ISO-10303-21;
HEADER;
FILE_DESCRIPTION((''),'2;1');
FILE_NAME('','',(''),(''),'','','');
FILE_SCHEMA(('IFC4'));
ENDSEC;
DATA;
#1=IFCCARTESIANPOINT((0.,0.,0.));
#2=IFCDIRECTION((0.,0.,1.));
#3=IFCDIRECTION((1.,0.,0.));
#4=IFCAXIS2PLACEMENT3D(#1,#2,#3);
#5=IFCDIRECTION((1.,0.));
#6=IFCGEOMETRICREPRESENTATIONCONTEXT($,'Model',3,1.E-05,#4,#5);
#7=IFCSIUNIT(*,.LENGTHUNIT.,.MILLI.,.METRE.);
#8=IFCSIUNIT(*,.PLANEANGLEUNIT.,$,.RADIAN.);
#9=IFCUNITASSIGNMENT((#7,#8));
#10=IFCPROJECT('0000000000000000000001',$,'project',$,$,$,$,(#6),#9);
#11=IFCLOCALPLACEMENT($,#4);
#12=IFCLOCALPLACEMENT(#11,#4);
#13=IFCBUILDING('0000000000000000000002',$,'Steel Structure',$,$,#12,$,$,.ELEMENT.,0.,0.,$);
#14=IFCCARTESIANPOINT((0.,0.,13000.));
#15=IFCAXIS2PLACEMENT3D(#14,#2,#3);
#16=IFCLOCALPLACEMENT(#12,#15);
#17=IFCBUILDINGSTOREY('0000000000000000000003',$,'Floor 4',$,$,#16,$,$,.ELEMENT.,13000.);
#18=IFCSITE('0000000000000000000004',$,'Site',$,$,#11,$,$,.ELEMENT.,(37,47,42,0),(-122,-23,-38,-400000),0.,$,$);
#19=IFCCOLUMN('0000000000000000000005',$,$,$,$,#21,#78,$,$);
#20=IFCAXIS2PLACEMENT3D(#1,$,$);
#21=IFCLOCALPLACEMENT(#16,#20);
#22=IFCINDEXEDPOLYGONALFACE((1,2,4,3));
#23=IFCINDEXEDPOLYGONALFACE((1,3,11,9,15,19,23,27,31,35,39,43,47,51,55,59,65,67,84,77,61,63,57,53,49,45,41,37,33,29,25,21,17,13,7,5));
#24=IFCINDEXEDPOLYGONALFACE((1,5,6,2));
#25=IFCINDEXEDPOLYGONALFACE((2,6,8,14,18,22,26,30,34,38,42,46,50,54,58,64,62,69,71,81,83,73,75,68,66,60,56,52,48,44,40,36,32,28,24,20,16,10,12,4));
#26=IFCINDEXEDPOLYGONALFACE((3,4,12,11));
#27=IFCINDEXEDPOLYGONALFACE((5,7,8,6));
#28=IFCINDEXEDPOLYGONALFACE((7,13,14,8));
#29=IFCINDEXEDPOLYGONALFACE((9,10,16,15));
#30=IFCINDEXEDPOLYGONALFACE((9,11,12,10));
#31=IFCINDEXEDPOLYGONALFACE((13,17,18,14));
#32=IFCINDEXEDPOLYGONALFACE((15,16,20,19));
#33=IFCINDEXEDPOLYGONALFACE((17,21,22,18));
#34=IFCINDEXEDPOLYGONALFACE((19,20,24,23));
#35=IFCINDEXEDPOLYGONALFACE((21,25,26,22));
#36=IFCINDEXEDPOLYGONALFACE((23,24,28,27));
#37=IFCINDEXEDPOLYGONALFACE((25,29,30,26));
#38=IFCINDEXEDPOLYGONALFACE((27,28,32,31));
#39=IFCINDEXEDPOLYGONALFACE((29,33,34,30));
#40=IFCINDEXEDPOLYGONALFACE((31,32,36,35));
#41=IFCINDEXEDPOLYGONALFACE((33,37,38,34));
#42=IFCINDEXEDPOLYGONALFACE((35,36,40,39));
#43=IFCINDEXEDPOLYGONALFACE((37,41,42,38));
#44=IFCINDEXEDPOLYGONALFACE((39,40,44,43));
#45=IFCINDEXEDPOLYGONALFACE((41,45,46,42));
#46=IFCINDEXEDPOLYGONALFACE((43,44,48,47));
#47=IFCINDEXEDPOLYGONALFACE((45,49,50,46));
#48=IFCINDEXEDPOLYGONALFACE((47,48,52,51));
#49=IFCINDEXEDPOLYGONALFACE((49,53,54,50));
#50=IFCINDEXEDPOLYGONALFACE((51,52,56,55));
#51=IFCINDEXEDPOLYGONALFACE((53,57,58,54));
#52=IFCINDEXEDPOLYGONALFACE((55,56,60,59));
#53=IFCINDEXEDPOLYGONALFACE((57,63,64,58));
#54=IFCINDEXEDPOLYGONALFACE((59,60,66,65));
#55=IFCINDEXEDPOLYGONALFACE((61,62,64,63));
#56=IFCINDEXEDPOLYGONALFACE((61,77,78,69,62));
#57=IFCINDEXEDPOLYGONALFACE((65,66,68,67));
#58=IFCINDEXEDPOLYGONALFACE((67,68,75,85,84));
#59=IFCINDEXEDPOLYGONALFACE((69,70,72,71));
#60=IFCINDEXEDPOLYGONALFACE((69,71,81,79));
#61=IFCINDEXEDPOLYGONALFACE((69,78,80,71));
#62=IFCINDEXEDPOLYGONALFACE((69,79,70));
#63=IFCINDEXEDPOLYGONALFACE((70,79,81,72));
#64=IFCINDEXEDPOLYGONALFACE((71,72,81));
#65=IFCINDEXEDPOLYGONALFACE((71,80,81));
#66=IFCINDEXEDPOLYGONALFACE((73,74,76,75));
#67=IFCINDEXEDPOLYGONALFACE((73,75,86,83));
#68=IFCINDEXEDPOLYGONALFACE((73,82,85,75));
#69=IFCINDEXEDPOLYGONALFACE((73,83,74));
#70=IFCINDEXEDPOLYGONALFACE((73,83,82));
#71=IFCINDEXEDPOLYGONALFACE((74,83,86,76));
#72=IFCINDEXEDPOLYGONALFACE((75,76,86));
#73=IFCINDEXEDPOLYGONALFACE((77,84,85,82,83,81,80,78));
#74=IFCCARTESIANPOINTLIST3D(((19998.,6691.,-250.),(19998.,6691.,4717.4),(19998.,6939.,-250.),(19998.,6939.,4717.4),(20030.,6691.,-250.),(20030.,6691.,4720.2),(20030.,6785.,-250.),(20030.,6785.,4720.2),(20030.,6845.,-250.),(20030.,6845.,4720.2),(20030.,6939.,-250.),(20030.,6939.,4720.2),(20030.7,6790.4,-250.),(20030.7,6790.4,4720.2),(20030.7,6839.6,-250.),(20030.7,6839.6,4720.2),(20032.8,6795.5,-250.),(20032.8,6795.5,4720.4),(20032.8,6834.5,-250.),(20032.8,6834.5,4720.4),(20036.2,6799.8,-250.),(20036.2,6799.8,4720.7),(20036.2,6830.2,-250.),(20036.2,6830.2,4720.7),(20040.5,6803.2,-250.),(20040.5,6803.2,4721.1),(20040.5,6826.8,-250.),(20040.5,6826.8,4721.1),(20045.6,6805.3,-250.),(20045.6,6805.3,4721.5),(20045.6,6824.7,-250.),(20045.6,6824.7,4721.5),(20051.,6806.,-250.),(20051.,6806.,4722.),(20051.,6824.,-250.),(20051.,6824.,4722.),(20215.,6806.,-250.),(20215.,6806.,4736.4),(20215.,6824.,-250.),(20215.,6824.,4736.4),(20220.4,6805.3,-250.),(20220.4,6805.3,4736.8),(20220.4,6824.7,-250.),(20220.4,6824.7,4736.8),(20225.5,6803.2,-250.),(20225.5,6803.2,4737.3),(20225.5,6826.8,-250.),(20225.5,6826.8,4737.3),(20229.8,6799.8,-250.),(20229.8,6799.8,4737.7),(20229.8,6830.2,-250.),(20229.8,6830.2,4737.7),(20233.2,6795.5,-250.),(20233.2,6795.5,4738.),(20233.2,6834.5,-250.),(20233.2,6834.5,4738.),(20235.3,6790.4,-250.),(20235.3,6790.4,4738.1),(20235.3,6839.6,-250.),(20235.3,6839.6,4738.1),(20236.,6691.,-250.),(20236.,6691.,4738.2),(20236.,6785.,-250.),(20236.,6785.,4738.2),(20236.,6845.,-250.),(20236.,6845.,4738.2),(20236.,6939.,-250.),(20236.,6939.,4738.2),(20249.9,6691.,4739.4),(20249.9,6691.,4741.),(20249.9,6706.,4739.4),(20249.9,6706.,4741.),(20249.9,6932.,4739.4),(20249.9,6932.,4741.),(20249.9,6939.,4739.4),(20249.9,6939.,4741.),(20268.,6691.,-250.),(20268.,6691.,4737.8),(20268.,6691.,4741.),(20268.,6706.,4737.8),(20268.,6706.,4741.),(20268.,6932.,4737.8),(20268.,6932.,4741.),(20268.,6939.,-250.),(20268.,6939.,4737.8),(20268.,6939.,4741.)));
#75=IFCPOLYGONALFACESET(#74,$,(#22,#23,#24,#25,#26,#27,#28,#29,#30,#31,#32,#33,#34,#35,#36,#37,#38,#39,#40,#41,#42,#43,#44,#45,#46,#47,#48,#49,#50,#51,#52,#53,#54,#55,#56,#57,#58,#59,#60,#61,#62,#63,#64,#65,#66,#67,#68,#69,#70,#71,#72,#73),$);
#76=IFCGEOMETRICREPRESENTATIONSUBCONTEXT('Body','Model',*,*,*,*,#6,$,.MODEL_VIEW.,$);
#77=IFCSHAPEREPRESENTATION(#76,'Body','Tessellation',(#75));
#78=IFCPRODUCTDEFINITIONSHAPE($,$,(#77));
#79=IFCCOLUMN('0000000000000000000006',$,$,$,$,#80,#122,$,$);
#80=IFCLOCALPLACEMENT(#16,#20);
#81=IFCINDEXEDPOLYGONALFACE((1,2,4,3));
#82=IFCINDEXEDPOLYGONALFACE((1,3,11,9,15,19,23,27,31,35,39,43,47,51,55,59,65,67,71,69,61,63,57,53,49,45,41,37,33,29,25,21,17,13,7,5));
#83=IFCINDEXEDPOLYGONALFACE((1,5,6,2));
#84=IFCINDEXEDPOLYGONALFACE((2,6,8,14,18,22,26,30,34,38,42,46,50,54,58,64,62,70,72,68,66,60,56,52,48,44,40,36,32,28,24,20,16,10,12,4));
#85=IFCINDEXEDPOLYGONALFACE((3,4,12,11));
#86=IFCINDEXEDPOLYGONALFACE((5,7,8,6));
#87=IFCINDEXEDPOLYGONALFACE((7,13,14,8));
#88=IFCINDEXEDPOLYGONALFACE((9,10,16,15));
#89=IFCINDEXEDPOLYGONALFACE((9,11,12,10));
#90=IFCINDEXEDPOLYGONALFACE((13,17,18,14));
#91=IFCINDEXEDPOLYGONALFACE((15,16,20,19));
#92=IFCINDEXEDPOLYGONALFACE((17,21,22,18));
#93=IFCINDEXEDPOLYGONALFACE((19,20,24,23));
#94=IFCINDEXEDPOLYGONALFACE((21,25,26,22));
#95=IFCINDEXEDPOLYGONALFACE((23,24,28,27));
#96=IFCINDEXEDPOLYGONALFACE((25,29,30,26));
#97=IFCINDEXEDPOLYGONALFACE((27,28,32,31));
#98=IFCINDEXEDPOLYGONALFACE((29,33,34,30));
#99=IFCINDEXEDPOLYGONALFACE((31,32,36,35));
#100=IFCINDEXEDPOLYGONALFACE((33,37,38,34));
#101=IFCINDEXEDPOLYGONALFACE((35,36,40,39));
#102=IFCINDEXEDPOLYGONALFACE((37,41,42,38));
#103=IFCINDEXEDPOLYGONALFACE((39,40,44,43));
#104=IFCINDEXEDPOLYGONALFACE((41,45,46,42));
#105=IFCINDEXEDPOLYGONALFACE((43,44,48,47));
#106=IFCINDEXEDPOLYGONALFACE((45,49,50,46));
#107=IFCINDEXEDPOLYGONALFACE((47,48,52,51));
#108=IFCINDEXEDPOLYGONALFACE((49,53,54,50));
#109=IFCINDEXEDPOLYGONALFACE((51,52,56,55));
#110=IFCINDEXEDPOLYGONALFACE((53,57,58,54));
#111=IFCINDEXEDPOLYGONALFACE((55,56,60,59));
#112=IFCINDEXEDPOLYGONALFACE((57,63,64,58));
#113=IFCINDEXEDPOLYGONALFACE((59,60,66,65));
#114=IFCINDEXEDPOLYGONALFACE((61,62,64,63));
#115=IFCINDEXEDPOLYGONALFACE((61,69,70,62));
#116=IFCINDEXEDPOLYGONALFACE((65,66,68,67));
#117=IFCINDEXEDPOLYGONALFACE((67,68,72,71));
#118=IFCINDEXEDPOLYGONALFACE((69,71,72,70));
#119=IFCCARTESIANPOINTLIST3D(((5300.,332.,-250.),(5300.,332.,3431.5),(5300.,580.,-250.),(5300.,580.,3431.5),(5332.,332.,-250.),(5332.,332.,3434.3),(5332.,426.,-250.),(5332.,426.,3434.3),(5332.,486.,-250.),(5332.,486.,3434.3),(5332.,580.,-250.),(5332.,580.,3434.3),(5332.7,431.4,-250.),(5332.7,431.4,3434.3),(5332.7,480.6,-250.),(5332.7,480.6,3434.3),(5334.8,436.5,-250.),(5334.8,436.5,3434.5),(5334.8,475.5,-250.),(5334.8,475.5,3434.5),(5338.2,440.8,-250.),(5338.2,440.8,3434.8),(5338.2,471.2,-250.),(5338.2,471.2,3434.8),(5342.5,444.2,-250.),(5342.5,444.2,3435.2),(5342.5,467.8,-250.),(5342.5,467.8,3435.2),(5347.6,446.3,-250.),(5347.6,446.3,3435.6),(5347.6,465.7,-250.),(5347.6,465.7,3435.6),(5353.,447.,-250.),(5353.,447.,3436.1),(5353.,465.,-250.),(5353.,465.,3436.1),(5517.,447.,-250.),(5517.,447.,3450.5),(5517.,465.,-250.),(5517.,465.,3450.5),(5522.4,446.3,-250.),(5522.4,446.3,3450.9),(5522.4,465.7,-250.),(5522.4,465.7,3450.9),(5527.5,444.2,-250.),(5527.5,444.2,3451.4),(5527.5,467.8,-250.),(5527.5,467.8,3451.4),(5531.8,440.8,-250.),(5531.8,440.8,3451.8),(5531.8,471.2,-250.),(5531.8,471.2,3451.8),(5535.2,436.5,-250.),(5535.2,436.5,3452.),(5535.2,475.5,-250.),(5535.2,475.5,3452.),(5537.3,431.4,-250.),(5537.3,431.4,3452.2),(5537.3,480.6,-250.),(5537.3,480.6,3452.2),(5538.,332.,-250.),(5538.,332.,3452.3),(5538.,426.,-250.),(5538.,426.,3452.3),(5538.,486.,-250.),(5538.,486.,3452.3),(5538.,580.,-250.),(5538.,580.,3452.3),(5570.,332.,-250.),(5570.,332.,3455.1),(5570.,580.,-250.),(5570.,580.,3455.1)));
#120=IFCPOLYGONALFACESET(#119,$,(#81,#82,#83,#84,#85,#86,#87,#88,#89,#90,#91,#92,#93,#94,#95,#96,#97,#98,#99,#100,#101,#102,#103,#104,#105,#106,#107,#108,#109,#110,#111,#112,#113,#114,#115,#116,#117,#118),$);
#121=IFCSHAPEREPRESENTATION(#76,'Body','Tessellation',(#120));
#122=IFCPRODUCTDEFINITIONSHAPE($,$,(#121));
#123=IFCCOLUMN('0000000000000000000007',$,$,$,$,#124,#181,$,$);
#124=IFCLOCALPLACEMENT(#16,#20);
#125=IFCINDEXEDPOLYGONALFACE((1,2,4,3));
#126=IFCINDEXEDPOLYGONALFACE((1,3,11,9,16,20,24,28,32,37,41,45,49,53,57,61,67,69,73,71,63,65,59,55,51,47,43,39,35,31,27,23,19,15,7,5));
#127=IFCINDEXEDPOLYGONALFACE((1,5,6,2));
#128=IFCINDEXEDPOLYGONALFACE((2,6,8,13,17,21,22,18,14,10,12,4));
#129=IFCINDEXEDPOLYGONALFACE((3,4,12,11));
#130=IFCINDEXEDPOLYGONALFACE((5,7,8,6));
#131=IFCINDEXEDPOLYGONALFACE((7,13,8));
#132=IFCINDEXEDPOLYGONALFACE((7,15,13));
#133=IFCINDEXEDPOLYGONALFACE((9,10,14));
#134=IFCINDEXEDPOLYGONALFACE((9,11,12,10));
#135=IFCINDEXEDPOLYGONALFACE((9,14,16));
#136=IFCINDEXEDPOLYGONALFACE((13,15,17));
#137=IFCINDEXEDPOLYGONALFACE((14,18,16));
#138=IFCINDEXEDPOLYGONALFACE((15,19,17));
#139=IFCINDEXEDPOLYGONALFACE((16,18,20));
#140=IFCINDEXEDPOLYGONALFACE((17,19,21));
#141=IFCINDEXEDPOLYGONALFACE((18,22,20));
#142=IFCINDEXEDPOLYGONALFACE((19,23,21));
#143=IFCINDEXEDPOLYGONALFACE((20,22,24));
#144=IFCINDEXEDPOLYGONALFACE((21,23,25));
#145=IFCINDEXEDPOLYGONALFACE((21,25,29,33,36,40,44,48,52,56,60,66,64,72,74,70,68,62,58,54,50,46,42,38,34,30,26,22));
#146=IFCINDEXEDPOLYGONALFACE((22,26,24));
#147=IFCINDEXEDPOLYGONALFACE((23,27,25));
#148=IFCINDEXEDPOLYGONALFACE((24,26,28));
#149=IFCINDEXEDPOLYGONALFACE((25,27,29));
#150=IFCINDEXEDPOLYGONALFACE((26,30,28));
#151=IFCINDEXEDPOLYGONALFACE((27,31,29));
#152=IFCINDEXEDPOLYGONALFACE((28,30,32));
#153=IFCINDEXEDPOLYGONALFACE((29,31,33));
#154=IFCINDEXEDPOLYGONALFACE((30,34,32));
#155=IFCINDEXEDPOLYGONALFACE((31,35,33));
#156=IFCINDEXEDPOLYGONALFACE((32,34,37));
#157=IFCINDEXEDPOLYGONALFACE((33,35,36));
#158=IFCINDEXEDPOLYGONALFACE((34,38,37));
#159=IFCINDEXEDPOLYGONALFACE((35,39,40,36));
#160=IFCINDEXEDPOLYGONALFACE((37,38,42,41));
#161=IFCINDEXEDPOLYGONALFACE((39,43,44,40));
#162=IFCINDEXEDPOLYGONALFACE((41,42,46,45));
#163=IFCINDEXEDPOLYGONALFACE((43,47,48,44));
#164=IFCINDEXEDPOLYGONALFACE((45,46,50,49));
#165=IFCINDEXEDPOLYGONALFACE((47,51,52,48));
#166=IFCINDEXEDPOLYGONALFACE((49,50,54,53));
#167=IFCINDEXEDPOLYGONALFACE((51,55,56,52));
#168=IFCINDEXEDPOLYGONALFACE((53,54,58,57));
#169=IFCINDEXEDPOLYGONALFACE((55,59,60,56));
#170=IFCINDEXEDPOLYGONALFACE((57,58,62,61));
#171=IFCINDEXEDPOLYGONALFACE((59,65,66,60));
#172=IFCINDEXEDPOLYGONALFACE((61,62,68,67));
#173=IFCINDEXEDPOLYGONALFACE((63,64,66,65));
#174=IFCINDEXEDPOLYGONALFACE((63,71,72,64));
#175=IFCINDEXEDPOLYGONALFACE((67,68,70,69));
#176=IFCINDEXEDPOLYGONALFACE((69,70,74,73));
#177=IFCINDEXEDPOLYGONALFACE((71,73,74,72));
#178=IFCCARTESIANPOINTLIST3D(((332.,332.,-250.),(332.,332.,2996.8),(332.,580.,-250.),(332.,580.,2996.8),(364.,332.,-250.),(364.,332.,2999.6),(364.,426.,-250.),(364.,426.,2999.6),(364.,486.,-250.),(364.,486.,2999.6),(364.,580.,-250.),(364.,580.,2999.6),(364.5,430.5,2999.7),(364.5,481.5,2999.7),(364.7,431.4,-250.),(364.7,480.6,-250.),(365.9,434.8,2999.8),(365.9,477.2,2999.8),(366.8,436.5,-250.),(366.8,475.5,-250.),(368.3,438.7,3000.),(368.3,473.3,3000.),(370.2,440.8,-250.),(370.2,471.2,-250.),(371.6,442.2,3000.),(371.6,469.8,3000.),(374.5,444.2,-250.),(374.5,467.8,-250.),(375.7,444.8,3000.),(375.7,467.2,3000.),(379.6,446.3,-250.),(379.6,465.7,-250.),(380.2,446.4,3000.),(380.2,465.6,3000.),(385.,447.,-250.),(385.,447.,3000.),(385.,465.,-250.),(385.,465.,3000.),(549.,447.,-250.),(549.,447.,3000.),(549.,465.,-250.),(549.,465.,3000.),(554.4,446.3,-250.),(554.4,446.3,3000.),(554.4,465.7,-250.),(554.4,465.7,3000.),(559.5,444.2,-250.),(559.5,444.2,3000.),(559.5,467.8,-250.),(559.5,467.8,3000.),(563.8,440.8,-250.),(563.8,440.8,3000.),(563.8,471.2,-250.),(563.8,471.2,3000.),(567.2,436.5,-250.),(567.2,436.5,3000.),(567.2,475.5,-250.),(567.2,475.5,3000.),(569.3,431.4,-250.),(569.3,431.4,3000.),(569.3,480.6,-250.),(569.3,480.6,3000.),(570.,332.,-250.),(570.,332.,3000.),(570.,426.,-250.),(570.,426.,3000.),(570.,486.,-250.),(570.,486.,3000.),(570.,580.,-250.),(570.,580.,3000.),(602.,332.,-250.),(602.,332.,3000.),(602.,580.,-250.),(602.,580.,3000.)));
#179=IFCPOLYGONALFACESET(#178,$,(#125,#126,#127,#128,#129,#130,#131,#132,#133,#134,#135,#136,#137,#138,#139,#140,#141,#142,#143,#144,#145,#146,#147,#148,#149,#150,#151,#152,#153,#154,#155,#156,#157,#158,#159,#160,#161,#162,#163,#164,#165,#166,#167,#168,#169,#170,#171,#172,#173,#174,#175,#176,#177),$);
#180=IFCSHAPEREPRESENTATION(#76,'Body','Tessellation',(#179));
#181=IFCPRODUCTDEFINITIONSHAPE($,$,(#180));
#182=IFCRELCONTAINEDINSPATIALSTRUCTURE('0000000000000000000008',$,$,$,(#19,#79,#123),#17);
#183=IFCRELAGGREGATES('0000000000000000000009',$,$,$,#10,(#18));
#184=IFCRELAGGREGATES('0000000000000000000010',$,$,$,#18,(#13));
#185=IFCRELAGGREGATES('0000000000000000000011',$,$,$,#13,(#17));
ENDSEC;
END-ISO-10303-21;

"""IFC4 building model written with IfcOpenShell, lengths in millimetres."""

from ifc_helpers import new_model, si_unit, direction, frame, origin_with_axes, origin_2d_with_axis, place, context, subcontext, project, spatial, polyline, i_section, outline, extrude, boolean, clip, bounded_halfspace, element, save


model = new_model("IFC4")

# Units and contexts
model_context = context("Model", 3, precision=1e-05, world=origin_with_axes(), true_north=direction((1.0, 0.0)))
body_context = subcontext(model_context, "Body", "Model", "MODEL_VIEW")
ifc_project = project(units=[si_unit("LENGTHUNIT", "METRE", prefix="MILLI"), si_unit("PLANEANGLEUNIT", "RADIAN")], contexts=[model_context])

# Site, building, storey
site_placement = place(None, origin_with_axes())
site = spatial("IfcSite", under=ifc_project, at=site_placement, Name="Site", CompositionType="ELEMENT", RefLatitude=(37, 47, 42, 0), RefLongitude=(-122, -23, -38, -400000), RefElevation=0.0)
building_placement = place(site_placement, origin_with_axes())
building = spatial("IfcBuilding", under=site, at=building_placement, Name="Steel Structure", CompositionType="ELEMENT", ElevationOfRefHeight=0.0, ElevationOfTerrain=0.0)
storey_placement = place(building_placement, frame((0.0, 0.0, 13000.0), z_axis=(0.0, 0.0, 1.0), x_axis=(1.0, 0.0, 0.0)))
storey = spatial("IfcBuildingStorey", under=building, at=storey_placement, Name="Floor 4", CompositionType="ELEMENT", Elevation=13000.0)

# Columns
column_1_placement = place(storey_placement, frame((20133.0, 6815.0, -250.0), z_axis=(0.0, 0.0, 1.0), x_axis=(0.0, 1.0, 0.0)))
element("IfcColumn", 1, at=column_1_placement, inside=storey, context=body_context, shape_type="SolidModel", body=[
    boolean("DIFFERENCE", boolean("DIFFERENCE", clip(extrude(i_section(OverallWidth=248.0, OverallDepth=270.0, WebThickness=18.0, FlangeThickness=32.0, FilletRadius=21.0, at=origin_2d_with_axis()), origin_with_axes(), (0.0, 0.0, 1.0), 4991.0), bounded_halfspace(frame((-6815.0, 21519.4, 3096.5), z_axis=(0.0, 0.087156, 0.996195), x_axis=(-1.0, 0.0, 0.0)), False, origin_with_axes(), polyline([(-124.0, 103.0), (-30.0, 103.0), (-9.0, 82.0), (-9.0, -82.0), (-30.0, -103.0), (-124.0, -103.0), (-124.0, -116.9), (-109.0, -116.9), (-109.0, -135.0), (117.0, -135.0), (117.0, -116.9), (124.0, -116.9), (124.0, -103.0), (30.0, -103.0), (9.0, -82.0), (9.0, 82.0), (30.0, 103.0), (124.0, 103.0), (124.0, 135.0), (-124.0, 135.0), (-124.0, 103.0)]))), extrude(outline(polyline([(1.6, 6.0), (0.0, -12.1), (-1.6, 6.0), (1.6, 6.0)])), frame((117.0, -129.0, 4989.4), z_axis=(1.0, 0.0, 0.0), x_axis=(0.0, 0.0, 1.0)), (0.0, 0.0, 1.0), 7.0)), extrude(outline(polyline([(0.0, -12.1), (-1.6, 6.0), (1.6, 6.0), (0.0, -12.1)])), frame((-124.0, -129.0, 4989.4), z_axis=(1.0, 0.0, 0.0), x_axis=(0.0, 0.0, 1.0)), (0.0, 0.0, 1.0), 15.0)),
])
column_2_placement = place(storey_placement, frame((5435.0, 456.0, -250.0), z_axis=(0.0, 0.0, 1.0), x_axis=(0.0, 1.0, 0.0)))
element("IfcColumn", 2, at=column_2_placement, inside=storey, context=body_context, shape_type="Clipping", body=[
    clip(extrude(i_section(OverallWidth=248.0, OverallDepth=270.0, WebThickness=18.0, FlangeThickness=32.0, FilletRadius=21.0, at=origin_2d_with_axis()), origin_with_axes(), (0.0, 0.0, 1.0), 3705.1), bounded_halfspace(frame((-456.0, 6821.4, 3096.5), z_axis=(0.0, 0.087156, 0.996195), x_axis=(-1.0, 0.0, 0.0)), False, origin_with_axes(), polyline([(-124.0, -135.0), (124.0, -135.0), (124.0, -103.0), (30.0, -103.0), (9.0, -82.0), (9.0, 82.0), (30.0, 103.0), (124.0, 103.0), (124.0, 135.0), (-124.0, 135.0), (-124.0, 103.0), (-30.0, 103.0), (-9.0, 82.0), (-9.0, -82.0), (-30.0, -103.0), (-124.0, -103.0), (-124.0, -135.0)]))),
])
column_3_placement = place(storey_placement, frame((467.0, 456.0, -250.0), z_axis=(0.0, 0.0, 1.0), x_axis=(0.0, 1.0, 0.0)))
element("IfcColumn", 3, at=column_3_placement, inside=storey, context=body_context, shape_type="Clipping", body=[
    clip(extrude(i_section(OverallWidth=248.0, OverallDepth=270.0, WebThickness=18.0, FlangeThickness=32.0, FilletRadius=21.0, at=origin_2d_with_axis()), origin_with_axes(), (0.0, 0.0, 1.0), 3250.0), bounded_halfspace(frame((-456.0, 1853.4, 3096.5), z_axis=(0.0, 0.087156, 0.996195), x_axis=(-1.0, 0.0, 0.0)), False, origin_with_axes(), polyline([(124.0, 135.0), (-124.0, 135.0), (-124.0, 103.0), (-30.0, 103.0), (-17.3, 98.7), (17.3, 98.7), (30.0, 103.0), (124.0, 103.0), (124.0, 135.0)]))),
])

save(model, "model.ifc")
